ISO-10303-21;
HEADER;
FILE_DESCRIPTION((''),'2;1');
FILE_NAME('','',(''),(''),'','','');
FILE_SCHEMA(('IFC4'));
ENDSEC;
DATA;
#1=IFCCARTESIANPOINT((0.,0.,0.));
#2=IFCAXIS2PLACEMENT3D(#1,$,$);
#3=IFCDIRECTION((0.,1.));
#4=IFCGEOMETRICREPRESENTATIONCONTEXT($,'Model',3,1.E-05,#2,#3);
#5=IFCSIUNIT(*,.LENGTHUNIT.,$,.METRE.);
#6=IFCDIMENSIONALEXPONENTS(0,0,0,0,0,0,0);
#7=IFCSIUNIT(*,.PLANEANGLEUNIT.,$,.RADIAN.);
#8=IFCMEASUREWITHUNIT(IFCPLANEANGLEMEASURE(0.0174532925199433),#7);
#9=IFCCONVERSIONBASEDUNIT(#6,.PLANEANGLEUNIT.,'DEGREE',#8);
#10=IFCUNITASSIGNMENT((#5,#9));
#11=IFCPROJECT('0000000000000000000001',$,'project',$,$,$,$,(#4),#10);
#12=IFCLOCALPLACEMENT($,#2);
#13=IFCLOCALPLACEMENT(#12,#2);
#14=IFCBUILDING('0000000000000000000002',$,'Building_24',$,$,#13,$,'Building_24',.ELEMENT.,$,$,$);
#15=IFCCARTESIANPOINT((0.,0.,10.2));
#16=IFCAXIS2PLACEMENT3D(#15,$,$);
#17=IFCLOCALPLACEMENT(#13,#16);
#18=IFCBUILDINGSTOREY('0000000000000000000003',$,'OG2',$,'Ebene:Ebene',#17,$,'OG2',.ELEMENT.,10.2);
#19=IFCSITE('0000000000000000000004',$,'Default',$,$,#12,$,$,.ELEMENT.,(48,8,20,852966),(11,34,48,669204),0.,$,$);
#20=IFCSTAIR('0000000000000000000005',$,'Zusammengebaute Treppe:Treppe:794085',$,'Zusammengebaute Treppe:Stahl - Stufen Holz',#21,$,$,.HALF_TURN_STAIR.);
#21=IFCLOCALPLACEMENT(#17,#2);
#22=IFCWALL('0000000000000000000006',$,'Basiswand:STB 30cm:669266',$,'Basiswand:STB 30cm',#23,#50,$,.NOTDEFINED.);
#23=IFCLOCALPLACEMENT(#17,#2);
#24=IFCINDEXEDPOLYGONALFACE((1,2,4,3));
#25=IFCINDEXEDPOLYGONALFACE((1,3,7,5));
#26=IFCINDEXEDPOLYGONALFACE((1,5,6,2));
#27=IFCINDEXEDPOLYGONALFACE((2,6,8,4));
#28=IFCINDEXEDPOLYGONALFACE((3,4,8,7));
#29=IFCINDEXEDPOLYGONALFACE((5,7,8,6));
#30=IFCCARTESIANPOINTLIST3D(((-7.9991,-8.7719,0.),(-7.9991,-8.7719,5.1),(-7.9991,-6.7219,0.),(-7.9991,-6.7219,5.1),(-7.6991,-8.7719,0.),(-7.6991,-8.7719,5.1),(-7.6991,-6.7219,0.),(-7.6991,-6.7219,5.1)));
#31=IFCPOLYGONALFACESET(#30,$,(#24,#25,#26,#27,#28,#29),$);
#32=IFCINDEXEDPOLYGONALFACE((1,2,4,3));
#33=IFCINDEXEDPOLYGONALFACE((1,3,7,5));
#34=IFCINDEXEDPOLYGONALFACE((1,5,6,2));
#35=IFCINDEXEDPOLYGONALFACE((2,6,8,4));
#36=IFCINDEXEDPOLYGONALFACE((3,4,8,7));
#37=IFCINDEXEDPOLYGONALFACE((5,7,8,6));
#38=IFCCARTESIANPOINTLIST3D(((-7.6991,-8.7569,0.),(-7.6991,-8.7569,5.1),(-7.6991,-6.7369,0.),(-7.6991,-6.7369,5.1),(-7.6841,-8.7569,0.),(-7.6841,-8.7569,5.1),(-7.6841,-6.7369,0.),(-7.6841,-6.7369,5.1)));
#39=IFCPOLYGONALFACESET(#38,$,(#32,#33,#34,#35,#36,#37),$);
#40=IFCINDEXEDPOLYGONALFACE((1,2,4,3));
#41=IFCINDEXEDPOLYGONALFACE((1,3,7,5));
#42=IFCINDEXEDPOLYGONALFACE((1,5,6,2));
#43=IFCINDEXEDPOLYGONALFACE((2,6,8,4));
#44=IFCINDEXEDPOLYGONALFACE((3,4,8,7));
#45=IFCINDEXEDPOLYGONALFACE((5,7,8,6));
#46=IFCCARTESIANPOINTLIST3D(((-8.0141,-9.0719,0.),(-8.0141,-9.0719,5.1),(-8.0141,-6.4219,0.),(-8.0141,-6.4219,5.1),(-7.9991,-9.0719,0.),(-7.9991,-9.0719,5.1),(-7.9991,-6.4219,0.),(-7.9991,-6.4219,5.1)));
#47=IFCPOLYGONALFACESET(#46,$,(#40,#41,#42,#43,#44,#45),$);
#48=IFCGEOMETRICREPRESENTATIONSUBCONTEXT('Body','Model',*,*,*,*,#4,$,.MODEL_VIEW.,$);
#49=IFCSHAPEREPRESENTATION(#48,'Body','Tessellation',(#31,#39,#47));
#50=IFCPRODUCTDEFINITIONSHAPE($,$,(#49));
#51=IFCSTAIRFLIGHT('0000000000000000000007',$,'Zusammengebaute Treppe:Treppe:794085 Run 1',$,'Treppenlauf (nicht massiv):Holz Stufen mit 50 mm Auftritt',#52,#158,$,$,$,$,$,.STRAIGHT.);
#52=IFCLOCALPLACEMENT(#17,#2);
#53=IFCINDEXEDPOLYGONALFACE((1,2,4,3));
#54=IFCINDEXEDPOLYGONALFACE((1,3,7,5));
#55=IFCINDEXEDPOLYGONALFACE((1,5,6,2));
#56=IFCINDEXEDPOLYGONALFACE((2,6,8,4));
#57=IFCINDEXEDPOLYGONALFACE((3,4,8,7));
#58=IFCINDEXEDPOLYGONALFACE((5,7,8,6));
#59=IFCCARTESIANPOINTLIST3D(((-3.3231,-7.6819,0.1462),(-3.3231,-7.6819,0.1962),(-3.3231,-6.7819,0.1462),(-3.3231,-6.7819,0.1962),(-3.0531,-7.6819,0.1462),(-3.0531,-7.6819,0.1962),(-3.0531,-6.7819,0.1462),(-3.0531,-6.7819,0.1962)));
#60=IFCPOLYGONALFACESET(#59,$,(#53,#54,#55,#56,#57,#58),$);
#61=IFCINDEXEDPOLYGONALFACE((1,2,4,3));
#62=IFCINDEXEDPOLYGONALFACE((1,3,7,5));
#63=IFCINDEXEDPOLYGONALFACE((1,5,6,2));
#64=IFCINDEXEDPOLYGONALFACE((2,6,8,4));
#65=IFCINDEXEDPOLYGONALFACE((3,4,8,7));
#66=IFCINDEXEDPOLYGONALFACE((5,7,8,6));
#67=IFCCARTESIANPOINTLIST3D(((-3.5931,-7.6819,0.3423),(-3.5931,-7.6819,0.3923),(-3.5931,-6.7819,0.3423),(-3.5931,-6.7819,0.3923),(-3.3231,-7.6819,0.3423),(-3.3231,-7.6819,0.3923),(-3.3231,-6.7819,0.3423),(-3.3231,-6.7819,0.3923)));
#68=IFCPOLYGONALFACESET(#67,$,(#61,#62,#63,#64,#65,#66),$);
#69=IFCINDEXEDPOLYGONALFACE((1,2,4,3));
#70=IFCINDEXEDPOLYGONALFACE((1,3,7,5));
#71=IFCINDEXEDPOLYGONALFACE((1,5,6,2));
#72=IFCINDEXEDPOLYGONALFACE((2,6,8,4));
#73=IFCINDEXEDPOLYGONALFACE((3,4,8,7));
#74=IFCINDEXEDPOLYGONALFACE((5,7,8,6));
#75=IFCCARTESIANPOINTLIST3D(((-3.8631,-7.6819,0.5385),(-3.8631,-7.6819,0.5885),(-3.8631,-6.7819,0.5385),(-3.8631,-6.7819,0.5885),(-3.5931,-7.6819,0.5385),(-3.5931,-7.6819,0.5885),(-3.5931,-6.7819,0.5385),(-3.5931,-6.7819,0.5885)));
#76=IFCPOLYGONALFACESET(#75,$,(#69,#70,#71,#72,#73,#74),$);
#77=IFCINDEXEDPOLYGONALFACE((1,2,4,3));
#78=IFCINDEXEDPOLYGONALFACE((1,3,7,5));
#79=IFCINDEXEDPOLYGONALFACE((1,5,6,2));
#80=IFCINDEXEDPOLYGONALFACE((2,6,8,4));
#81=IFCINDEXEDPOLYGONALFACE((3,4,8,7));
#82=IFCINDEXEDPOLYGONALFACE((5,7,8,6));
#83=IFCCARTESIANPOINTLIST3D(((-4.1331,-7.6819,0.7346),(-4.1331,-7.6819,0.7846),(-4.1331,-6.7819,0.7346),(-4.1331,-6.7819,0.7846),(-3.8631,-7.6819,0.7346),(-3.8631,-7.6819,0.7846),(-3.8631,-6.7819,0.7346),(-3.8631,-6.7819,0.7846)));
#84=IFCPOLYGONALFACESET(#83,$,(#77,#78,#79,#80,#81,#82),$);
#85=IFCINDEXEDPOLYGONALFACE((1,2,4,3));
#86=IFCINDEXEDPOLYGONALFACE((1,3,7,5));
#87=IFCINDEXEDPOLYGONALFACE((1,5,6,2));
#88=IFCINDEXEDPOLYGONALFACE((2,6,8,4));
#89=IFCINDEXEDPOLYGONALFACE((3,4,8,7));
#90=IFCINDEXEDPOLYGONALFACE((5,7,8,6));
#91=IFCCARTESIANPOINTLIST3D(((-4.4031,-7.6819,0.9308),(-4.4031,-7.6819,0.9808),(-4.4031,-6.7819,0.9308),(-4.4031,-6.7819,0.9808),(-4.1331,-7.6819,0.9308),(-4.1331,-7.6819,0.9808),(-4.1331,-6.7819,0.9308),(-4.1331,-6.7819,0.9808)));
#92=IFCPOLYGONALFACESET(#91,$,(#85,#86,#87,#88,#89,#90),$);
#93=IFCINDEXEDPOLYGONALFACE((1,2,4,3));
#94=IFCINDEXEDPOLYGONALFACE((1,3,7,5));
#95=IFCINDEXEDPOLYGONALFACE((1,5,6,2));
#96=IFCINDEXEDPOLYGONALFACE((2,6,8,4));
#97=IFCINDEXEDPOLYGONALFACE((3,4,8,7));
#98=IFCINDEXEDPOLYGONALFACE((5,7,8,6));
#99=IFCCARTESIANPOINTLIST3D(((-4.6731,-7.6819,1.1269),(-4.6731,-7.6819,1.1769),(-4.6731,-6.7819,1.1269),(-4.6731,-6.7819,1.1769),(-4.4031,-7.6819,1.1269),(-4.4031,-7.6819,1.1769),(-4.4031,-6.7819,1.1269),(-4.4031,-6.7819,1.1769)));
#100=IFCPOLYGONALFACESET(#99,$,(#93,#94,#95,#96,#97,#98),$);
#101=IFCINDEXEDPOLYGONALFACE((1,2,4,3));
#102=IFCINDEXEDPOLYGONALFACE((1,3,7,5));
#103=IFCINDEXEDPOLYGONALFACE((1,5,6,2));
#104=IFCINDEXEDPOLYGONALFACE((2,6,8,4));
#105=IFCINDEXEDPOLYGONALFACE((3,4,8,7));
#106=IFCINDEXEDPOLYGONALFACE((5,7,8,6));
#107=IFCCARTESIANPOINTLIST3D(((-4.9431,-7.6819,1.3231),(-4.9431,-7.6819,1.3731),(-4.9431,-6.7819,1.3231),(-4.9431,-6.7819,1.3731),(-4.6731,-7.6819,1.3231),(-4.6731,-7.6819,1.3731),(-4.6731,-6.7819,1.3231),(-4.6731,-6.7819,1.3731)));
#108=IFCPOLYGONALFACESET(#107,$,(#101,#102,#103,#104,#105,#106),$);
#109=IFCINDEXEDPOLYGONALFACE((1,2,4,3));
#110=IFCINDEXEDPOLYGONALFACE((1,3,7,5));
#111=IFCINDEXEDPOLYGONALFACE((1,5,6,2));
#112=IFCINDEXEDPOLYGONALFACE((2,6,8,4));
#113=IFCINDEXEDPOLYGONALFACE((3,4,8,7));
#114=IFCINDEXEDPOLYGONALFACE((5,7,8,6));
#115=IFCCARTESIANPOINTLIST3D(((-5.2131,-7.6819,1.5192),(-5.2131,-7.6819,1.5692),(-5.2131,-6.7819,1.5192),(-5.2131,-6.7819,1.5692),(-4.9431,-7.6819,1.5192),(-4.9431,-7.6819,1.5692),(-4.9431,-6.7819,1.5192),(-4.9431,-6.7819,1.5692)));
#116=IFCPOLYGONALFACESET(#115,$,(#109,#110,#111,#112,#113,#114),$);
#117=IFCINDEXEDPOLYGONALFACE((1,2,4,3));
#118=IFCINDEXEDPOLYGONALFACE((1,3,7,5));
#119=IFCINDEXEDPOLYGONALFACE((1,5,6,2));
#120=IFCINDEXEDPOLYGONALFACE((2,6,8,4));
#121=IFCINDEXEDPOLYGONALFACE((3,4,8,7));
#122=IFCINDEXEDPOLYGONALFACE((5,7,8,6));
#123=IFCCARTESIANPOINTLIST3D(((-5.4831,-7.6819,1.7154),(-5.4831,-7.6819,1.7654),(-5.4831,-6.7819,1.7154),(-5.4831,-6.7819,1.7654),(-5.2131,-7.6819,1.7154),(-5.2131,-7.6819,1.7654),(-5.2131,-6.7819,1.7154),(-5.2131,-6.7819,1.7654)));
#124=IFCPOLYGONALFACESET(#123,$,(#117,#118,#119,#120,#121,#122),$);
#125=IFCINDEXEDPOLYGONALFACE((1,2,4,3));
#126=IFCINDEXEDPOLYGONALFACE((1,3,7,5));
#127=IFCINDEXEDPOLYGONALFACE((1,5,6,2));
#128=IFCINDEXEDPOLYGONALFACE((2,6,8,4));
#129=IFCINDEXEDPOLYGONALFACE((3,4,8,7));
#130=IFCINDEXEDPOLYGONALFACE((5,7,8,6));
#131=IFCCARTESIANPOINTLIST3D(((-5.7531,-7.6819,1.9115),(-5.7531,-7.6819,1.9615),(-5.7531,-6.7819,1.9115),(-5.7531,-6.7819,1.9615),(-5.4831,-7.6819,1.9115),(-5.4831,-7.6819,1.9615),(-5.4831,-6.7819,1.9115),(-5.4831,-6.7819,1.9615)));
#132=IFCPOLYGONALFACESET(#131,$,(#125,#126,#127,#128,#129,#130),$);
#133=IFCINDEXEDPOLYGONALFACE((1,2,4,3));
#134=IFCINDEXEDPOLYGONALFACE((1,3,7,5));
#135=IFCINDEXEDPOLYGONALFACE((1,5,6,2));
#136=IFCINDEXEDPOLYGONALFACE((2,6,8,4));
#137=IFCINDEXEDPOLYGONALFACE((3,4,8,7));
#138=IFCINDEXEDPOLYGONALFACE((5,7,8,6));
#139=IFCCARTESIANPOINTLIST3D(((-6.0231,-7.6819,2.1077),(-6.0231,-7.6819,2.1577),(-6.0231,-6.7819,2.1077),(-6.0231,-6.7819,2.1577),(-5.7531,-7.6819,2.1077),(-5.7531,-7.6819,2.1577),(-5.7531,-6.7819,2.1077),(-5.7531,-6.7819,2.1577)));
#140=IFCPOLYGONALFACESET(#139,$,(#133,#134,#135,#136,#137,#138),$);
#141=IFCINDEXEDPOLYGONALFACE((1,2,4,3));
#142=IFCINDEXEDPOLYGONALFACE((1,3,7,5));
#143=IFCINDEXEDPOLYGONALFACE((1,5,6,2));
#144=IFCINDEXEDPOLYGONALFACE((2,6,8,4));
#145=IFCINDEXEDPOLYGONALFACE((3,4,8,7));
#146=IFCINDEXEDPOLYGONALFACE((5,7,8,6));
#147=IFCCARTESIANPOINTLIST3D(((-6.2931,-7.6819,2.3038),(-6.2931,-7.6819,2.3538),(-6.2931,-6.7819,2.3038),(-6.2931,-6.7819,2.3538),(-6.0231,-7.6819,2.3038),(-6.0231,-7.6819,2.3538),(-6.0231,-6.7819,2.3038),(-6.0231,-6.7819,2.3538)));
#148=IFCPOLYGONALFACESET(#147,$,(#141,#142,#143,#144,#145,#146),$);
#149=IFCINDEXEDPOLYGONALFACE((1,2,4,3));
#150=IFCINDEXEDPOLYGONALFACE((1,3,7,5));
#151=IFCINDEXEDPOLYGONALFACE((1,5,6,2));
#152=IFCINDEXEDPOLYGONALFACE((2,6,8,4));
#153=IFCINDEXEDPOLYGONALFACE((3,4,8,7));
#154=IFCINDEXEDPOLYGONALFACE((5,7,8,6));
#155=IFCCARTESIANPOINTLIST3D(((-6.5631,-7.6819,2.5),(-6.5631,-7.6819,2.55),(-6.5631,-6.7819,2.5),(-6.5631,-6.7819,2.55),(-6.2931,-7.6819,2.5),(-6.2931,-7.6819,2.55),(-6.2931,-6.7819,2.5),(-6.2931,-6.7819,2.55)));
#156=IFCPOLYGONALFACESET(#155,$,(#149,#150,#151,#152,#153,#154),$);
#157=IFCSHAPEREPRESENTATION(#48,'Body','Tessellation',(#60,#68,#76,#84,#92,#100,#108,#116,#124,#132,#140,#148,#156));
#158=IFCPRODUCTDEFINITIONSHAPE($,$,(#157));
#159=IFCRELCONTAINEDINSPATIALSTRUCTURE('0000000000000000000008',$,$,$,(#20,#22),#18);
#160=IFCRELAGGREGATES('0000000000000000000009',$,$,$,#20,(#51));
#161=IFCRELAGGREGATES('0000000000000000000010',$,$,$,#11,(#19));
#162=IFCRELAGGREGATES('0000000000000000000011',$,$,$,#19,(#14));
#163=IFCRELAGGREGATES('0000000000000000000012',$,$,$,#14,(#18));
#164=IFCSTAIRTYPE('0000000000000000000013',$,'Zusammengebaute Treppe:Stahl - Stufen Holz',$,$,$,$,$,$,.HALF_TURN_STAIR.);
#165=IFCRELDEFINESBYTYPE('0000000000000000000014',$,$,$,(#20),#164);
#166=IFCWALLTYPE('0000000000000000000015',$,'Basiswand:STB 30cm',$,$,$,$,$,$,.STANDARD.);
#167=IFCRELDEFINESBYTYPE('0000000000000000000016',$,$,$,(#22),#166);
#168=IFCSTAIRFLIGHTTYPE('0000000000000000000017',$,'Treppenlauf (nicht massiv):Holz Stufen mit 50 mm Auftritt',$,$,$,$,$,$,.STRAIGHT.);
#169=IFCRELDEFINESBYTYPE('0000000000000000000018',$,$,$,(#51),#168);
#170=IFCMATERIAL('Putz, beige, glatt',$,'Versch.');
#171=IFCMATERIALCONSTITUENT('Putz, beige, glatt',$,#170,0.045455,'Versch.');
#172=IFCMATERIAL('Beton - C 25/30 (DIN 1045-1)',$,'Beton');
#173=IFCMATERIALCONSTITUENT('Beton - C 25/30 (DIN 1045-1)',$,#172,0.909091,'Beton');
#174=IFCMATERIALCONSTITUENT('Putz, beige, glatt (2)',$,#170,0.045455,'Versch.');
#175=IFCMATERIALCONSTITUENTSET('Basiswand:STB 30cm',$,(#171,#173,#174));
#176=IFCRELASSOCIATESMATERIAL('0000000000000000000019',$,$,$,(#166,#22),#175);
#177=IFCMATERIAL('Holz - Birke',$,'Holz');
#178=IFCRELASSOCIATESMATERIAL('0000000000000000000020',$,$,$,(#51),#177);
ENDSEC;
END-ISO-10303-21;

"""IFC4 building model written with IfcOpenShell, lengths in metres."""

from ifc_helpers import new_model, entity, si_unit, converted_unit, direction, frame, origin, place, context, subcontext, project, spatial, indexed_curve, outline, extrude, material, constituent, constituent_set, type_object, element, aggregate, save


model = new_model("IFC4")

# Units and contexts
model_context = context("Model", 3, precision=1e-05, world=origin(), true_north=direction((0.0, 1.0)))
body_context = subcontext(model_context, "Body", "Model", "MODEL_VIEW")
ifc_project = project(units=[si_unit("LENGTHUNIT", "METRE"), converted_unit("PLANEANGLEUNIT", "DEGREE", entity("IfcPlaneAngleMeasure", 0.0174532925199433), si_unit("PLANEANGLEUNIT", "RADIAN"), dimensions=[0, 0, 0, 0, 0, 0, 0])], contexts=[model_context])

# Site, building, storey
site_placement = place(None, origin())
site = spatial("IfcSite", under=ifc_project, at=site_placement, Name="Default", CompositionType="ELEMENT", RefLatitude=(48, 8, 20, 852966), RefLongitude=(11, 34, 48, 669204), RefElevation=0.0)
building_placement = place(site_placement, origin())
building = spatial("IfcBuilding", under=site, at=building_placement, Name="Building_24", LongName="Building_24", CompositionType="ELEMENT")
storey_placement = place(building_placement, frame((0.0, 0.0, 10.2)))
storey = spatial("IfcBuildingStorey", under=building, at=storey_placement, Name="OG2", ObjectType="Ebene:Ebene", LongName="OG2", CompositionType="ELEMENT", Elevation=10.2)

# Stair
stair_type_1 = type_object("IfcStairType", Name="Zusammengebaute Treppe:Stahl - Stufen Holz", PredefinedType="HALF_TURN_STAIR")
stair_1_placement = place(storey_placement, origin())
stair_1 = element("IfcStair", 1, at=stair_1_placement, inside=storey, type_object=stair_type_1, Name="Zusammengebaute Treppe:Treppe:794085", ObjectType="Zusammengebaute Treppe:Stahl - Stufen Holz", PredefinedType="HALF_TURN_STAIR")
ifc_material_1 = material(Name="Holz - Birke", Category="Holz")

# Shared definitions
ifc_material_2 = material(Name="Putz, beige, glatt", Category="Versch.")
ifc_material_3 = material(Name="Beton - C 25/30 (DIN 1045-1)", Category="Beton")

# Wall
ifc_constituent_1 = constituent(ifc_material_2, Name="Putz, beige, glatt", Category="Versch.", fraction=0.045455)
ifc_constituent_2 = constituent(ifc_material_3, Name="Beton - C 25/30 (DIN 1045-1)", Category="Beton", fraction=0.909091)
ifc_constituent_3 = constituent(ifc_material_2, Name="Putz, beige, glatt (2)", Category="Versch.", fraction=0.045455)
ifc_constituent_set_1 = constituent_set(constituents=[ifc_constituent_1, ifc_constituent_2, ifc_constituent_3], Name="Basiswand:STB 30cm")
wall_type_1 = type_object("IfcWallType", Name="Basiswand:STB 30cm", PredefinedType="STANDARD", material=ifc_constituent_set_1)
wall_1_placement = place(storey_placement, frame((-7.8491, -6.7369, 0.0), z_axis=(0.0, 0.0, 1.0), x_axis=(0.0, -1.0, 0.0)))
element("IfcWall", 2, at=wall_1_placement, inside=storey, type_object=wall_type_1, material=ifc_constituent_set_1, Name="Basiswand:STB 30cm:669266", ObjectType="Basiswand:STB 30cm", PredefinedType="NOTDEFINED", context=body_context, shape_type="SweptSolid", body=[
    extrude(outline(indexed_curve([(-1.025, -0.15), (1.025, -0.15), (1.025, 0.15), (-1.025, 0.15), (-1.025, -0.15)], self_intersect=False)), frame((1.01, 0.0, 0.0)), (0.0, 0.0, 1.0), 5.1),
    extrude(outline(indexed_curve([(-0.0075, -1.01), (0.0075, -1.01), (0.0075, 1.01), (-0.0075, 1.01), (-0.0075, -1.01)], self_intersect=False)), frame((1.01, 0.1575, 0.0), z_axis=(0.0, 0.0, 1.0), x_axis=(0.0, -1.0, 0.0)), (0.0, 0.0, 1.0), 5.1),
    extrude(outline(indexed_curve([(-0.0075, -1.325), (0.0075, -1.325), (0.0075, 1.325), (-0.0075, 1.325), (-0.0075, -1.325)], self_intersect=False)), frame((1.01, -0.1575, 0.0), z_axis=(0.0, 0.0, 1.0), x_axis=(0.0, 1.0, 0.0)), (0.0, 0.0, 1.0), 5.1),
])

# Stair flight
stair_flight_type_1 = type_object("IfcStairFlightType", Name="Treppenlauf (nicht massiv):Holz Stufen mit 50 mm Auftritt", PredefinedType="STRAIGHT")
stair_flight_1_placement = place(stair_1_placement, origin())
stair_flight_1 = element("IfcStairFlight", 3, at=stair_flight_1_placement, type_object=stair_flight_type_1, material=ifc_material_1, Name="Zusammengebaute Treppe:Treppe:794085 Run 1", ObjectType="Treppenlauf (nicht massiv):Holz Stufen mit 50 mm Auftritt", PredefinedType="STRAIGHT", context=body_context, shape_type="SweptSolid", body=[
    extrude(outline(indexed_curve([(-0.135, -0.45), (0.135, -0.45), (0.135, 0.45), (-0.135, 0.45), (-0.135, -0.45)], self_intersect=False)), frame((-3.1881, -7.2319, 0.1462)), (0.0, 0.0, 1.0), 0.05),
    extrude(outline(indexed_curve([(-0.135, -0.45), (0.135, -0.45), (0.135, 0.45), (-0.135, 0.45), (-0.135, -0.45)], self_intersect=False)), frame((-3.4581, -7.2319, 0.3423)), (0.0, 0.0, 1.0), 0.05),
    extrude(outline(indexed_curve([(-0.135, -0.45), (0.135, -0.45), (0.135, 0.45), (-0.135, 0.45), (-0.135, -0.45)], self_intersect=False)), frame((-3.7281, -7.2319, 0.5385)), (0.0, 0.0, 1.0), 0.05),
    extrude(outline(indexed_curve([(-0.135, -0.45), (0.135, -0.45), (0.135, 0.45), (-0.135, 0.45), (-0.135, -0.45)], self_intersect=False)), frame((-3.9981, -7.2319, 0.7346)), (0.0, 0.0, 1.0), 0.05),
    extrude(outline(indexed_curve([(-0.135, -0.45), (0.135, -0.45), (0.135, 0.45), (-0.135, 0.45), (-0.135, -0.45)], self_intersect=False)), frame((-4.2681, -7.2319, 0.9308)), (0.0, 0.0, 1.0), 0.05),
    extrude(outline(indexed_curve([(-0.135, -0.45), (0.135, -0.45), (0.135, 0.45), (-0.135, 0.45), (-0.135, -0.45)], self_intersect=False)), frame((-4.5381, -7.2319, 1.1269)), (0.0, 0.0, 1.0), 0.05),
    extrude(outline(indexed_curve([(-0.135, -0.45), (0.135, -0.45), (0.135, 0.45), (-0.135, 0.45), (-0.135, -0.45)], self_intersect=False)), frame((-4.8081, -7.2319, 1.3231)), (0.0, 0.0, 1.0), 0.05),
    extrude(outline(indexed_curve([(-0.135, -0.45), (0.135, -0.45), (0.135, 0.45), (-0.135, 0.45), (-0.135, -0.45)], self_intersect=False)), frame((-5.0781, -7.2319, 1.5192)), (0.0, 0.0, 1.0), 0.05),
    extrude(outline(indexed_curve([(-0.135, -0.45), (0.135, -0.45), (0.135, 0.45), (-0.135, 0.45), (-0.135, -0.45)], self_intersect=False)), frame((-5.3481, -7.2319, 1.7154)), (0.0, 0.0, 1.0), 0.05),
    extrude(outline(indexed_curve([(-0.135, -0.45), (0.135, -0.45), (0.135, 0.45), (-0.135, 0.45), (-0.135, -0.45)], self_intersect=False)), frame((-5.6181, -7.2319, 1.9115)), (0.0, 0.0, 1.0), 0.05),
    extrude(outline(indexed_curve([(-0.135, -0.45), (0.135, -0.45), (0.135, 0.45), (-0.135, 0.45), (-0.135, -0.45)], self_intersect=False)), frame((-5.8881, -7.2319, 2.1077)), (0.0, 0.0, 1.0), 0.05),
    extrude(outline(indexed_curve([(-0.135, -0.45), (0.135, -0.45), (0.135, 0.45), (-0.135, 0.45), (-0.135, -0.45)], self_intersect=False)), frame((-6.1581, -7.2319, 2.3038)), (0.0, 0.0, 1.0), 0.05),
    extrude(outline(indexed_curve([(-0.135, -0.45), (0.135, -0.45), (0.135, 0.45), (-0.135, 0.45), (-0.135, -0.45)], self_intersect=False)), frame((-6.4281, -7.2319, 2.5)), (0.0, 0.0, 1.0), 0.05),
])
aggregate(stair_1, [stair_flight_1])

save(model, "model.ifc")
